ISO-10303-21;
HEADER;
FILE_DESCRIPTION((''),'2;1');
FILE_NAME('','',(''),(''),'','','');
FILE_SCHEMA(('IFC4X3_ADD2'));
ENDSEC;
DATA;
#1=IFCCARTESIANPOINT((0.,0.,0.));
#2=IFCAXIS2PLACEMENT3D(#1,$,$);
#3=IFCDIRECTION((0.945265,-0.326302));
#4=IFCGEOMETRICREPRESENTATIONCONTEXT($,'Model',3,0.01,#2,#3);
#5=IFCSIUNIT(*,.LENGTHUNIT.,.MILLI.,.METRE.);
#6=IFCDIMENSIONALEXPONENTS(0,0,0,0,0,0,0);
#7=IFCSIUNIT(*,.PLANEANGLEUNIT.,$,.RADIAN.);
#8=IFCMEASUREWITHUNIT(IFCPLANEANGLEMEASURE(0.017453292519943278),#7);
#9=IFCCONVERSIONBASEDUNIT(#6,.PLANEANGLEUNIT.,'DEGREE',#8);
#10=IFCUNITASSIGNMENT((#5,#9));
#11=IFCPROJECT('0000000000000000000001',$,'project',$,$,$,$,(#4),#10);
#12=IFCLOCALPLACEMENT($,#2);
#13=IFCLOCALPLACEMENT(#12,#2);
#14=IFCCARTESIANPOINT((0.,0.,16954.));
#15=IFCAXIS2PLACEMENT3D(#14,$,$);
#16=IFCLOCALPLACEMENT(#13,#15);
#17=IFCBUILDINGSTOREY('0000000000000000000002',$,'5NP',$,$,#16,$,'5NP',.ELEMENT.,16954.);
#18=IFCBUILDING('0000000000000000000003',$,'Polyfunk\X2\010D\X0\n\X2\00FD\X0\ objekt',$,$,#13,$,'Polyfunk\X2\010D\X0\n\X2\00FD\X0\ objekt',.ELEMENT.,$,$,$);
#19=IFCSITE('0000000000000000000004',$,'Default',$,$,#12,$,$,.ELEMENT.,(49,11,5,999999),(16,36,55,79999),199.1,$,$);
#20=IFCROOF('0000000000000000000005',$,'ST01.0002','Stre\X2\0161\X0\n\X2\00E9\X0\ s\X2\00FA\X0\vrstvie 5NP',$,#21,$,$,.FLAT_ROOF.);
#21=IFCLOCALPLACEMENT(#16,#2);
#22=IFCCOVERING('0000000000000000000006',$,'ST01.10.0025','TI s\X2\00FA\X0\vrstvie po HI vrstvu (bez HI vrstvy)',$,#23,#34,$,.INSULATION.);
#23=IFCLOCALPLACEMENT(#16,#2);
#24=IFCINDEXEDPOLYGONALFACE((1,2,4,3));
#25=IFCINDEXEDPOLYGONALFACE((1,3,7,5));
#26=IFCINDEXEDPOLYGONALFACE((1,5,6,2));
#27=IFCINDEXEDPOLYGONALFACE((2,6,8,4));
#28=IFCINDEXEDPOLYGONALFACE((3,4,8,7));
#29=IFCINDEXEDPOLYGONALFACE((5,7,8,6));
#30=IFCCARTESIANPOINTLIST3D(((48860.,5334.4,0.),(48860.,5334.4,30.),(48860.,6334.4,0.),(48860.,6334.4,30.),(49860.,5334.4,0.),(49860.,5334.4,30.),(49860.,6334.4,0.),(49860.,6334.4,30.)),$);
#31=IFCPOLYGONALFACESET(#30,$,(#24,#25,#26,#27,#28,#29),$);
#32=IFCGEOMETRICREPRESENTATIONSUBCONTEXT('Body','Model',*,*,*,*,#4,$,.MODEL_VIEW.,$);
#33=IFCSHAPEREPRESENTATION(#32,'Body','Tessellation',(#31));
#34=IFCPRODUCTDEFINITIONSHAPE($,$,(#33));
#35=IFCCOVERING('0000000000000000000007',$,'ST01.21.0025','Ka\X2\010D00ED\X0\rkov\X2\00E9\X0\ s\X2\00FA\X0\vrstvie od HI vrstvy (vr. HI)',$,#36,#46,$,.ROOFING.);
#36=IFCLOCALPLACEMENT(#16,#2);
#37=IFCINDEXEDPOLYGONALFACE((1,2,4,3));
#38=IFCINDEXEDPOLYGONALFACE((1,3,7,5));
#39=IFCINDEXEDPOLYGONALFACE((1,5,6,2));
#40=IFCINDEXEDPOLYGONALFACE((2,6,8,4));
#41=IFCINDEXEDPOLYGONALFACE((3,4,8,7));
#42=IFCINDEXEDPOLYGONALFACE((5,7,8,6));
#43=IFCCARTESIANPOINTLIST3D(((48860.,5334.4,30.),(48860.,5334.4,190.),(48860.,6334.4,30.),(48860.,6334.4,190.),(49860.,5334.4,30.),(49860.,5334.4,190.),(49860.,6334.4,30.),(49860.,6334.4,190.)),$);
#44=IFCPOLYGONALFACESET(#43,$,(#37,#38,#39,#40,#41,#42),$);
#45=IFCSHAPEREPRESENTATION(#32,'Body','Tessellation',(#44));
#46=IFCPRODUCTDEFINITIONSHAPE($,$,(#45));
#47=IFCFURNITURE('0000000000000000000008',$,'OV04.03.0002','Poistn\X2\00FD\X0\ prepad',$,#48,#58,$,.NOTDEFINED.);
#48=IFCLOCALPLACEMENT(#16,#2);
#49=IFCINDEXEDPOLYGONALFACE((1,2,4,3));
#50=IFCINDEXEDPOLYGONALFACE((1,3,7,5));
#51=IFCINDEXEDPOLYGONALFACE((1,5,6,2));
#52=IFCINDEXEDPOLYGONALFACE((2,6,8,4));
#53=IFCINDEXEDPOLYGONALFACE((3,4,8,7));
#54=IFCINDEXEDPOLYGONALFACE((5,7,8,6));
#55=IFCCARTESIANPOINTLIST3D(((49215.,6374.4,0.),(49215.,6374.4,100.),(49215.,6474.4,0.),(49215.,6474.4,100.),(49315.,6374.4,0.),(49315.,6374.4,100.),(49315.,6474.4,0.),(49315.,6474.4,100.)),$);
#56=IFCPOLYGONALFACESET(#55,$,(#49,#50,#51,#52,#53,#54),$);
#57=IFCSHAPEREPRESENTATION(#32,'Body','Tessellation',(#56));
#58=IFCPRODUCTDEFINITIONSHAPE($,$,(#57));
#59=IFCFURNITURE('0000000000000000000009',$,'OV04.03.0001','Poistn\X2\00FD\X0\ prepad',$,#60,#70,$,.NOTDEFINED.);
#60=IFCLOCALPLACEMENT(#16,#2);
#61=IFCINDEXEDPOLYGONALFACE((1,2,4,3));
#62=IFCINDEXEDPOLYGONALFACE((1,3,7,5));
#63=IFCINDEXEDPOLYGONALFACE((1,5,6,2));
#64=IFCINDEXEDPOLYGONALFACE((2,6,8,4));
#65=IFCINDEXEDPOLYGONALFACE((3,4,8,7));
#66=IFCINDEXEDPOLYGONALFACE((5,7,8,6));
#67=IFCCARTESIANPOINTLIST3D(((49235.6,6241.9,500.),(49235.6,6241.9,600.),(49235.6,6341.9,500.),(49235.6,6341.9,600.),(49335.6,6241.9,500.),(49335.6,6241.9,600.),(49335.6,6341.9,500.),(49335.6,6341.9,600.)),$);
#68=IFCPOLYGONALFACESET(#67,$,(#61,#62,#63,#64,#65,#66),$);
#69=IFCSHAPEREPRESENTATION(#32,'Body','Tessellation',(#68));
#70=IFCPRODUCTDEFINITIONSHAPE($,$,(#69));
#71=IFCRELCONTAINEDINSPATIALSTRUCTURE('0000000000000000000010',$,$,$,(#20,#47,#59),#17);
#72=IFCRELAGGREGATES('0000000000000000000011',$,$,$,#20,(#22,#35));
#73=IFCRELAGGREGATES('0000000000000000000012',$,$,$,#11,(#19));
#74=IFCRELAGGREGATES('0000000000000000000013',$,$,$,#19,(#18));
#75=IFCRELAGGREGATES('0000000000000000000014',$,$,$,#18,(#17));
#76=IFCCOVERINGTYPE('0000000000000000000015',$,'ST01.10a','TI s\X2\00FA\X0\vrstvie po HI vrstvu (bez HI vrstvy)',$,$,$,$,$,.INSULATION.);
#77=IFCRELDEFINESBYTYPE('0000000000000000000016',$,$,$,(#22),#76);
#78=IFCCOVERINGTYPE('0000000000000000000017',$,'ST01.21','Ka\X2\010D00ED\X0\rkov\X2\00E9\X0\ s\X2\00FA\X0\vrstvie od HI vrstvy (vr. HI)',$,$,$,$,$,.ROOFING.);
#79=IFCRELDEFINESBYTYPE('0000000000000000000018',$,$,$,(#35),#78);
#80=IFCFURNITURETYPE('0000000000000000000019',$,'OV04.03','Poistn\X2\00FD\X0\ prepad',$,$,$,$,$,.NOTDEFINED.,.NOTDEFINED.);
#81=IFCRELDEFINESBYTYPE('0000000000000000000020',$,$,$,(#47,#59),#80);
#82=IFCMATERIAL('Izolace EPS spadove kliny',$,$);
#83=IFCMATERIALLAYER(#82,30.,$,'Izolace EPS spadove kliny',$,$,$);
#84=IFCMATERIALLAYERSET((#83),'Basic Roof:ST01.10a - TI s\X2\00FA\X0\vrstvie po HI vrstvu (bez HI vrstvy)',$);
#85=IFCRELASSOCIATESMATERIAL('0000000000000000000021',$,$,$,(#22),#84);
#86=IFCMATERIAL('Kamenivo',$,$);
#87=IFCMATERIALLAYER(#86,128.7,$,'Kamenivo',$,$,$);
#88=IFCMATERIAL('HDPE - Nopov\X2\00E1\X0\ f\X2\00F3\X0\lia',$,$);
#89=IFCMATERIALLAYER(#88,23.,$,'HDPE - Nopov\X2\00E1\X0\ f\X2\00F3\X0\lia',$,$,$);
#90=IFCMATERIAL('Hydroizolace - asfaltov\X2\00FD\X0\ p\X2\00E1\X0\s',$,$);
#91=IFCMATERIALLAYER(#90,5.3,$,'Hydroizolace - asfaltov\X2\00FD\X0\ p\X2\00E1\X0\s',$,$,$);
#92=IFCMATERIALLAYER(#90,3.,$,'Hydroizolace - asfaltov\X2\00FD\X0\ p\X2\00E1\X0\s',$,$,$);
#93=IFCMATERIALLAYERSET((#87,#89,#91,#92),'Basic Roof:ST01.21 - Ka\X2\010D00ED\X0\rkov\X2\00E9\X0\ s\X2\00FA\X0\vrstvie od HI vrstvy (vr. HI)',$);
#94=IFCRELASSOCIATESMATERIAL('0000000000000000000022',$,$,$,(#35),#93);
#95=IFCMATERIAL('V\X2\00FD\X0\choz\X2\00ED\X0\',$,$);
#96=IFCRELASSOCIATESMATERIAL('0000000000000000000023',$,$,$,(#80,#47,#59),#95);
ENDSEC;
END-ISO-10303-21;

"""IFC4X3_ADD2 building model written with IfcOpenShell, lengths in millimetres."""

from ifc_helpers import new_model, entity, si_unit, converted_unit, direction, frame, frame_2d, origin, origin_2d_with_axis, place, context, subcontext, project, spatial, rectangle, extrude, source, transform, mapped, material, layer, layer_set, type_object, type_shapes, element, aggregate, save


model = new_model("IFC4X3_ADD2")

# Units and contexts
model_context = context("Model", 3, precision=0.01, world=origin(), true_north=direction((0.945265, -0.326302)))
body_context = subcontext(model_context, "Body", "Model", "MODEL_VIEW")
ifc_project = project(units=[si_unit("LENGTHUNIT", "METRE", prefix="MILLI"), converted_unit("PLANEANGLEUNIT", "DEGREE", entity("IfcPlaneAngleMeasure", 0.017453292519943278), si_unit("PLANEANGLEUNIT", "RADIAN"), dimensions=[0, 0, 0, 0, 0, 0, 0])], contexts=[model_context])

# Site, building, storey
site_placement = place(None, origin())
site = spatial("IfcSite", under=ifc_project, at=site_placement, Name="Default", CompositionType="ELEMENT", RefLatitude=(49, 11, 5, 999999), RefLongitude=(16, 36, 55, 79999), RefElevation=199.1)
building_placement = place(site_placement, origin())
building = spatial("IfcBuilding", under=site, at=building_placement, Name="Polyfunkčný objekt", LongName="Polyfunkčný objekt", CompositionType="ELEMENT")
storey_placement = place(building_placement, frame((0.0, 0.0, 16954.0)))
storey = spatial("IfcBuildingStorey", under=building, at=storey_placement, Name="5NP", LongName="5NP", CompositionType="ELEMENT", Elevation=16954.0)

# Roof, coverings
roof = element("IfcRoof", 1, inside=storey, Name="ST01.0002", Description="Strešné súvrstvie 5NP", PredefinedType="FLAT_ROOF")
ifc_material_1 = material(Name="Izolace EPS spadove kliny")
ifc_layer_1 = layer(ifc_material_1, 30.0, Name="Izolace EPS spadove kliny")
ifc_layer_set_1 = layer_set([ifc_layer_1], Name="Basic Roof:ST01.10a - TI súvrstvie po HI vrstvu (bez HI vrstvy)")
covering_type_1 = type_object("IfcCoveringType", Name="ST01.10a", Description="TI súvrstvie po HI vrstvu (bez HI vrstvy)", PredefinedType="INSULATION")
placement_1 = place(storey_placement, frame((48860.0, 5334.4, 0.0)))
covering_1_placement = place(placement_1, origin())
covering_1 = element("IfcCovering", 2, at=covering_1_placement, type_object=covering_type_1, material=ifc_layer_set_1, Name="ST01.10.0025", Description="TI súvrstvie po HI vrstvu (bez HI vrstvy)", PredefinedType="INSULATION", context=body_context, shape_type="SweptSolid", body=[
    extrude(rectangle(XDim=1000.0, YDim=1000.0, at=origin_2d_with_axis()), frame((500.0, 500.0, 0.0)), (0.0, 0.0, 1.0), 30.0),
])
ifc_material_2 = material(Name="Kamenivo")
ifc_layer_2 = layer(ifc_material_2, 128.7, Name="Kamenivo")
ifc_material_3 = material(Name="HDPE - Nopová fólia")
ifc_layer_3 = layer(ifc_material_3, 23.0, Name="HDPE - Nopová fólia")
ifc_material_4 = material(Name="Hydroizolace - asfaltový pás")
ifc_layer_4 = layer(ifc_material_4, 5.3, Name="Hydroizolace - asfaltový pás")
ifc_layer_5 = layer(ifc_material_4, 3.0, Name="Hydroizolace - asfaltový pás")
ifc_layer_set_2 = layer_set([ifc_layer_2, ifc_layer_3, ifc_layer_4, ifc_layer_5], Name="Basic Roof:ST01.21 - Kačírkové súvrstvie od HI vrstvy (vr. HI)")
covering_type_2 = type_object("IfcCoveringType", Name="ST01.21", Description="Kačírkové súvrstvie od HI vrstvy (vr. HI)", PredefinedType="ROOFING")
placement_2 = place(storey_placement, frame((48860.0, 5334.4, 30.0)))
covering_2_placement = place(placement_2, origin())
covering_2 = element("IfcCovering", 3, at=covering_2_placement, type_object=covering_type_2, material=ifc_layer_set_2, Name="ST01.21.0025", Description="Kačírkové súvrstvie od HI vrstvy (vr. HI)", PredefinedType="ROOFING", context=body_context, shape_type="SweptSolid", body=[
    extrude(rectangle(XDim=1000.0, YDim=1000.0, at=frame_2d((0.0, 0.0), x_axis=(-1.0, 0.0))), frame((500.0, 500.0, 0.0)), (0.0, 0.0, 1.0), 160.0),
])
aggregate(roof, [covering_1, covering_2])

# Furniture
ifc_material_5 = material(Name="Výchozí")
furniture_type = type_object("IfcFurnitureType", Name="OV04.03", Description="Poistný prepad", AssemblyPlace="NOTDEFINED", PredefinedType="NOTDEFINED", material=ifc_material_5)
shared_shape = source(origin(), body_context, "Body", "SweptSolid", [
    extrude(rectangle(XDim=100.0, YDim=100.0, at=origin_2d_with_axis()), frame((0.0, 0.0, 0.0), z_axis=(0.0, 0.0, 1.0), x_axis=(0.0, 1.0, 0.0)), (0.0, 0.0, 1.0), 100.0),
])
type_shapes(furniture_type, [shared_shape])
for number, where, name in (
    (4, (49265.0, 6424.4, 0.0), "OV04.03.0002"),
    (5, (49285.6, 6291.9, 500.0), "OV04.03.0001"),
):
    element("IfcFurniture", number, at=place(storey_placement, frame(where)), inside=storey, type_object=furniture_type, material=ifc_material_5, Name=name, Description="Poistný prepad", PredefinedType="NOTDEFINED", context=body_context, shape_type="MappedRepresentation", body=[
        mapped(shared_shape, transform((0.0, 0.0, 0.0), scale=1.0)),
    ])

save(model, "model.ifc")
